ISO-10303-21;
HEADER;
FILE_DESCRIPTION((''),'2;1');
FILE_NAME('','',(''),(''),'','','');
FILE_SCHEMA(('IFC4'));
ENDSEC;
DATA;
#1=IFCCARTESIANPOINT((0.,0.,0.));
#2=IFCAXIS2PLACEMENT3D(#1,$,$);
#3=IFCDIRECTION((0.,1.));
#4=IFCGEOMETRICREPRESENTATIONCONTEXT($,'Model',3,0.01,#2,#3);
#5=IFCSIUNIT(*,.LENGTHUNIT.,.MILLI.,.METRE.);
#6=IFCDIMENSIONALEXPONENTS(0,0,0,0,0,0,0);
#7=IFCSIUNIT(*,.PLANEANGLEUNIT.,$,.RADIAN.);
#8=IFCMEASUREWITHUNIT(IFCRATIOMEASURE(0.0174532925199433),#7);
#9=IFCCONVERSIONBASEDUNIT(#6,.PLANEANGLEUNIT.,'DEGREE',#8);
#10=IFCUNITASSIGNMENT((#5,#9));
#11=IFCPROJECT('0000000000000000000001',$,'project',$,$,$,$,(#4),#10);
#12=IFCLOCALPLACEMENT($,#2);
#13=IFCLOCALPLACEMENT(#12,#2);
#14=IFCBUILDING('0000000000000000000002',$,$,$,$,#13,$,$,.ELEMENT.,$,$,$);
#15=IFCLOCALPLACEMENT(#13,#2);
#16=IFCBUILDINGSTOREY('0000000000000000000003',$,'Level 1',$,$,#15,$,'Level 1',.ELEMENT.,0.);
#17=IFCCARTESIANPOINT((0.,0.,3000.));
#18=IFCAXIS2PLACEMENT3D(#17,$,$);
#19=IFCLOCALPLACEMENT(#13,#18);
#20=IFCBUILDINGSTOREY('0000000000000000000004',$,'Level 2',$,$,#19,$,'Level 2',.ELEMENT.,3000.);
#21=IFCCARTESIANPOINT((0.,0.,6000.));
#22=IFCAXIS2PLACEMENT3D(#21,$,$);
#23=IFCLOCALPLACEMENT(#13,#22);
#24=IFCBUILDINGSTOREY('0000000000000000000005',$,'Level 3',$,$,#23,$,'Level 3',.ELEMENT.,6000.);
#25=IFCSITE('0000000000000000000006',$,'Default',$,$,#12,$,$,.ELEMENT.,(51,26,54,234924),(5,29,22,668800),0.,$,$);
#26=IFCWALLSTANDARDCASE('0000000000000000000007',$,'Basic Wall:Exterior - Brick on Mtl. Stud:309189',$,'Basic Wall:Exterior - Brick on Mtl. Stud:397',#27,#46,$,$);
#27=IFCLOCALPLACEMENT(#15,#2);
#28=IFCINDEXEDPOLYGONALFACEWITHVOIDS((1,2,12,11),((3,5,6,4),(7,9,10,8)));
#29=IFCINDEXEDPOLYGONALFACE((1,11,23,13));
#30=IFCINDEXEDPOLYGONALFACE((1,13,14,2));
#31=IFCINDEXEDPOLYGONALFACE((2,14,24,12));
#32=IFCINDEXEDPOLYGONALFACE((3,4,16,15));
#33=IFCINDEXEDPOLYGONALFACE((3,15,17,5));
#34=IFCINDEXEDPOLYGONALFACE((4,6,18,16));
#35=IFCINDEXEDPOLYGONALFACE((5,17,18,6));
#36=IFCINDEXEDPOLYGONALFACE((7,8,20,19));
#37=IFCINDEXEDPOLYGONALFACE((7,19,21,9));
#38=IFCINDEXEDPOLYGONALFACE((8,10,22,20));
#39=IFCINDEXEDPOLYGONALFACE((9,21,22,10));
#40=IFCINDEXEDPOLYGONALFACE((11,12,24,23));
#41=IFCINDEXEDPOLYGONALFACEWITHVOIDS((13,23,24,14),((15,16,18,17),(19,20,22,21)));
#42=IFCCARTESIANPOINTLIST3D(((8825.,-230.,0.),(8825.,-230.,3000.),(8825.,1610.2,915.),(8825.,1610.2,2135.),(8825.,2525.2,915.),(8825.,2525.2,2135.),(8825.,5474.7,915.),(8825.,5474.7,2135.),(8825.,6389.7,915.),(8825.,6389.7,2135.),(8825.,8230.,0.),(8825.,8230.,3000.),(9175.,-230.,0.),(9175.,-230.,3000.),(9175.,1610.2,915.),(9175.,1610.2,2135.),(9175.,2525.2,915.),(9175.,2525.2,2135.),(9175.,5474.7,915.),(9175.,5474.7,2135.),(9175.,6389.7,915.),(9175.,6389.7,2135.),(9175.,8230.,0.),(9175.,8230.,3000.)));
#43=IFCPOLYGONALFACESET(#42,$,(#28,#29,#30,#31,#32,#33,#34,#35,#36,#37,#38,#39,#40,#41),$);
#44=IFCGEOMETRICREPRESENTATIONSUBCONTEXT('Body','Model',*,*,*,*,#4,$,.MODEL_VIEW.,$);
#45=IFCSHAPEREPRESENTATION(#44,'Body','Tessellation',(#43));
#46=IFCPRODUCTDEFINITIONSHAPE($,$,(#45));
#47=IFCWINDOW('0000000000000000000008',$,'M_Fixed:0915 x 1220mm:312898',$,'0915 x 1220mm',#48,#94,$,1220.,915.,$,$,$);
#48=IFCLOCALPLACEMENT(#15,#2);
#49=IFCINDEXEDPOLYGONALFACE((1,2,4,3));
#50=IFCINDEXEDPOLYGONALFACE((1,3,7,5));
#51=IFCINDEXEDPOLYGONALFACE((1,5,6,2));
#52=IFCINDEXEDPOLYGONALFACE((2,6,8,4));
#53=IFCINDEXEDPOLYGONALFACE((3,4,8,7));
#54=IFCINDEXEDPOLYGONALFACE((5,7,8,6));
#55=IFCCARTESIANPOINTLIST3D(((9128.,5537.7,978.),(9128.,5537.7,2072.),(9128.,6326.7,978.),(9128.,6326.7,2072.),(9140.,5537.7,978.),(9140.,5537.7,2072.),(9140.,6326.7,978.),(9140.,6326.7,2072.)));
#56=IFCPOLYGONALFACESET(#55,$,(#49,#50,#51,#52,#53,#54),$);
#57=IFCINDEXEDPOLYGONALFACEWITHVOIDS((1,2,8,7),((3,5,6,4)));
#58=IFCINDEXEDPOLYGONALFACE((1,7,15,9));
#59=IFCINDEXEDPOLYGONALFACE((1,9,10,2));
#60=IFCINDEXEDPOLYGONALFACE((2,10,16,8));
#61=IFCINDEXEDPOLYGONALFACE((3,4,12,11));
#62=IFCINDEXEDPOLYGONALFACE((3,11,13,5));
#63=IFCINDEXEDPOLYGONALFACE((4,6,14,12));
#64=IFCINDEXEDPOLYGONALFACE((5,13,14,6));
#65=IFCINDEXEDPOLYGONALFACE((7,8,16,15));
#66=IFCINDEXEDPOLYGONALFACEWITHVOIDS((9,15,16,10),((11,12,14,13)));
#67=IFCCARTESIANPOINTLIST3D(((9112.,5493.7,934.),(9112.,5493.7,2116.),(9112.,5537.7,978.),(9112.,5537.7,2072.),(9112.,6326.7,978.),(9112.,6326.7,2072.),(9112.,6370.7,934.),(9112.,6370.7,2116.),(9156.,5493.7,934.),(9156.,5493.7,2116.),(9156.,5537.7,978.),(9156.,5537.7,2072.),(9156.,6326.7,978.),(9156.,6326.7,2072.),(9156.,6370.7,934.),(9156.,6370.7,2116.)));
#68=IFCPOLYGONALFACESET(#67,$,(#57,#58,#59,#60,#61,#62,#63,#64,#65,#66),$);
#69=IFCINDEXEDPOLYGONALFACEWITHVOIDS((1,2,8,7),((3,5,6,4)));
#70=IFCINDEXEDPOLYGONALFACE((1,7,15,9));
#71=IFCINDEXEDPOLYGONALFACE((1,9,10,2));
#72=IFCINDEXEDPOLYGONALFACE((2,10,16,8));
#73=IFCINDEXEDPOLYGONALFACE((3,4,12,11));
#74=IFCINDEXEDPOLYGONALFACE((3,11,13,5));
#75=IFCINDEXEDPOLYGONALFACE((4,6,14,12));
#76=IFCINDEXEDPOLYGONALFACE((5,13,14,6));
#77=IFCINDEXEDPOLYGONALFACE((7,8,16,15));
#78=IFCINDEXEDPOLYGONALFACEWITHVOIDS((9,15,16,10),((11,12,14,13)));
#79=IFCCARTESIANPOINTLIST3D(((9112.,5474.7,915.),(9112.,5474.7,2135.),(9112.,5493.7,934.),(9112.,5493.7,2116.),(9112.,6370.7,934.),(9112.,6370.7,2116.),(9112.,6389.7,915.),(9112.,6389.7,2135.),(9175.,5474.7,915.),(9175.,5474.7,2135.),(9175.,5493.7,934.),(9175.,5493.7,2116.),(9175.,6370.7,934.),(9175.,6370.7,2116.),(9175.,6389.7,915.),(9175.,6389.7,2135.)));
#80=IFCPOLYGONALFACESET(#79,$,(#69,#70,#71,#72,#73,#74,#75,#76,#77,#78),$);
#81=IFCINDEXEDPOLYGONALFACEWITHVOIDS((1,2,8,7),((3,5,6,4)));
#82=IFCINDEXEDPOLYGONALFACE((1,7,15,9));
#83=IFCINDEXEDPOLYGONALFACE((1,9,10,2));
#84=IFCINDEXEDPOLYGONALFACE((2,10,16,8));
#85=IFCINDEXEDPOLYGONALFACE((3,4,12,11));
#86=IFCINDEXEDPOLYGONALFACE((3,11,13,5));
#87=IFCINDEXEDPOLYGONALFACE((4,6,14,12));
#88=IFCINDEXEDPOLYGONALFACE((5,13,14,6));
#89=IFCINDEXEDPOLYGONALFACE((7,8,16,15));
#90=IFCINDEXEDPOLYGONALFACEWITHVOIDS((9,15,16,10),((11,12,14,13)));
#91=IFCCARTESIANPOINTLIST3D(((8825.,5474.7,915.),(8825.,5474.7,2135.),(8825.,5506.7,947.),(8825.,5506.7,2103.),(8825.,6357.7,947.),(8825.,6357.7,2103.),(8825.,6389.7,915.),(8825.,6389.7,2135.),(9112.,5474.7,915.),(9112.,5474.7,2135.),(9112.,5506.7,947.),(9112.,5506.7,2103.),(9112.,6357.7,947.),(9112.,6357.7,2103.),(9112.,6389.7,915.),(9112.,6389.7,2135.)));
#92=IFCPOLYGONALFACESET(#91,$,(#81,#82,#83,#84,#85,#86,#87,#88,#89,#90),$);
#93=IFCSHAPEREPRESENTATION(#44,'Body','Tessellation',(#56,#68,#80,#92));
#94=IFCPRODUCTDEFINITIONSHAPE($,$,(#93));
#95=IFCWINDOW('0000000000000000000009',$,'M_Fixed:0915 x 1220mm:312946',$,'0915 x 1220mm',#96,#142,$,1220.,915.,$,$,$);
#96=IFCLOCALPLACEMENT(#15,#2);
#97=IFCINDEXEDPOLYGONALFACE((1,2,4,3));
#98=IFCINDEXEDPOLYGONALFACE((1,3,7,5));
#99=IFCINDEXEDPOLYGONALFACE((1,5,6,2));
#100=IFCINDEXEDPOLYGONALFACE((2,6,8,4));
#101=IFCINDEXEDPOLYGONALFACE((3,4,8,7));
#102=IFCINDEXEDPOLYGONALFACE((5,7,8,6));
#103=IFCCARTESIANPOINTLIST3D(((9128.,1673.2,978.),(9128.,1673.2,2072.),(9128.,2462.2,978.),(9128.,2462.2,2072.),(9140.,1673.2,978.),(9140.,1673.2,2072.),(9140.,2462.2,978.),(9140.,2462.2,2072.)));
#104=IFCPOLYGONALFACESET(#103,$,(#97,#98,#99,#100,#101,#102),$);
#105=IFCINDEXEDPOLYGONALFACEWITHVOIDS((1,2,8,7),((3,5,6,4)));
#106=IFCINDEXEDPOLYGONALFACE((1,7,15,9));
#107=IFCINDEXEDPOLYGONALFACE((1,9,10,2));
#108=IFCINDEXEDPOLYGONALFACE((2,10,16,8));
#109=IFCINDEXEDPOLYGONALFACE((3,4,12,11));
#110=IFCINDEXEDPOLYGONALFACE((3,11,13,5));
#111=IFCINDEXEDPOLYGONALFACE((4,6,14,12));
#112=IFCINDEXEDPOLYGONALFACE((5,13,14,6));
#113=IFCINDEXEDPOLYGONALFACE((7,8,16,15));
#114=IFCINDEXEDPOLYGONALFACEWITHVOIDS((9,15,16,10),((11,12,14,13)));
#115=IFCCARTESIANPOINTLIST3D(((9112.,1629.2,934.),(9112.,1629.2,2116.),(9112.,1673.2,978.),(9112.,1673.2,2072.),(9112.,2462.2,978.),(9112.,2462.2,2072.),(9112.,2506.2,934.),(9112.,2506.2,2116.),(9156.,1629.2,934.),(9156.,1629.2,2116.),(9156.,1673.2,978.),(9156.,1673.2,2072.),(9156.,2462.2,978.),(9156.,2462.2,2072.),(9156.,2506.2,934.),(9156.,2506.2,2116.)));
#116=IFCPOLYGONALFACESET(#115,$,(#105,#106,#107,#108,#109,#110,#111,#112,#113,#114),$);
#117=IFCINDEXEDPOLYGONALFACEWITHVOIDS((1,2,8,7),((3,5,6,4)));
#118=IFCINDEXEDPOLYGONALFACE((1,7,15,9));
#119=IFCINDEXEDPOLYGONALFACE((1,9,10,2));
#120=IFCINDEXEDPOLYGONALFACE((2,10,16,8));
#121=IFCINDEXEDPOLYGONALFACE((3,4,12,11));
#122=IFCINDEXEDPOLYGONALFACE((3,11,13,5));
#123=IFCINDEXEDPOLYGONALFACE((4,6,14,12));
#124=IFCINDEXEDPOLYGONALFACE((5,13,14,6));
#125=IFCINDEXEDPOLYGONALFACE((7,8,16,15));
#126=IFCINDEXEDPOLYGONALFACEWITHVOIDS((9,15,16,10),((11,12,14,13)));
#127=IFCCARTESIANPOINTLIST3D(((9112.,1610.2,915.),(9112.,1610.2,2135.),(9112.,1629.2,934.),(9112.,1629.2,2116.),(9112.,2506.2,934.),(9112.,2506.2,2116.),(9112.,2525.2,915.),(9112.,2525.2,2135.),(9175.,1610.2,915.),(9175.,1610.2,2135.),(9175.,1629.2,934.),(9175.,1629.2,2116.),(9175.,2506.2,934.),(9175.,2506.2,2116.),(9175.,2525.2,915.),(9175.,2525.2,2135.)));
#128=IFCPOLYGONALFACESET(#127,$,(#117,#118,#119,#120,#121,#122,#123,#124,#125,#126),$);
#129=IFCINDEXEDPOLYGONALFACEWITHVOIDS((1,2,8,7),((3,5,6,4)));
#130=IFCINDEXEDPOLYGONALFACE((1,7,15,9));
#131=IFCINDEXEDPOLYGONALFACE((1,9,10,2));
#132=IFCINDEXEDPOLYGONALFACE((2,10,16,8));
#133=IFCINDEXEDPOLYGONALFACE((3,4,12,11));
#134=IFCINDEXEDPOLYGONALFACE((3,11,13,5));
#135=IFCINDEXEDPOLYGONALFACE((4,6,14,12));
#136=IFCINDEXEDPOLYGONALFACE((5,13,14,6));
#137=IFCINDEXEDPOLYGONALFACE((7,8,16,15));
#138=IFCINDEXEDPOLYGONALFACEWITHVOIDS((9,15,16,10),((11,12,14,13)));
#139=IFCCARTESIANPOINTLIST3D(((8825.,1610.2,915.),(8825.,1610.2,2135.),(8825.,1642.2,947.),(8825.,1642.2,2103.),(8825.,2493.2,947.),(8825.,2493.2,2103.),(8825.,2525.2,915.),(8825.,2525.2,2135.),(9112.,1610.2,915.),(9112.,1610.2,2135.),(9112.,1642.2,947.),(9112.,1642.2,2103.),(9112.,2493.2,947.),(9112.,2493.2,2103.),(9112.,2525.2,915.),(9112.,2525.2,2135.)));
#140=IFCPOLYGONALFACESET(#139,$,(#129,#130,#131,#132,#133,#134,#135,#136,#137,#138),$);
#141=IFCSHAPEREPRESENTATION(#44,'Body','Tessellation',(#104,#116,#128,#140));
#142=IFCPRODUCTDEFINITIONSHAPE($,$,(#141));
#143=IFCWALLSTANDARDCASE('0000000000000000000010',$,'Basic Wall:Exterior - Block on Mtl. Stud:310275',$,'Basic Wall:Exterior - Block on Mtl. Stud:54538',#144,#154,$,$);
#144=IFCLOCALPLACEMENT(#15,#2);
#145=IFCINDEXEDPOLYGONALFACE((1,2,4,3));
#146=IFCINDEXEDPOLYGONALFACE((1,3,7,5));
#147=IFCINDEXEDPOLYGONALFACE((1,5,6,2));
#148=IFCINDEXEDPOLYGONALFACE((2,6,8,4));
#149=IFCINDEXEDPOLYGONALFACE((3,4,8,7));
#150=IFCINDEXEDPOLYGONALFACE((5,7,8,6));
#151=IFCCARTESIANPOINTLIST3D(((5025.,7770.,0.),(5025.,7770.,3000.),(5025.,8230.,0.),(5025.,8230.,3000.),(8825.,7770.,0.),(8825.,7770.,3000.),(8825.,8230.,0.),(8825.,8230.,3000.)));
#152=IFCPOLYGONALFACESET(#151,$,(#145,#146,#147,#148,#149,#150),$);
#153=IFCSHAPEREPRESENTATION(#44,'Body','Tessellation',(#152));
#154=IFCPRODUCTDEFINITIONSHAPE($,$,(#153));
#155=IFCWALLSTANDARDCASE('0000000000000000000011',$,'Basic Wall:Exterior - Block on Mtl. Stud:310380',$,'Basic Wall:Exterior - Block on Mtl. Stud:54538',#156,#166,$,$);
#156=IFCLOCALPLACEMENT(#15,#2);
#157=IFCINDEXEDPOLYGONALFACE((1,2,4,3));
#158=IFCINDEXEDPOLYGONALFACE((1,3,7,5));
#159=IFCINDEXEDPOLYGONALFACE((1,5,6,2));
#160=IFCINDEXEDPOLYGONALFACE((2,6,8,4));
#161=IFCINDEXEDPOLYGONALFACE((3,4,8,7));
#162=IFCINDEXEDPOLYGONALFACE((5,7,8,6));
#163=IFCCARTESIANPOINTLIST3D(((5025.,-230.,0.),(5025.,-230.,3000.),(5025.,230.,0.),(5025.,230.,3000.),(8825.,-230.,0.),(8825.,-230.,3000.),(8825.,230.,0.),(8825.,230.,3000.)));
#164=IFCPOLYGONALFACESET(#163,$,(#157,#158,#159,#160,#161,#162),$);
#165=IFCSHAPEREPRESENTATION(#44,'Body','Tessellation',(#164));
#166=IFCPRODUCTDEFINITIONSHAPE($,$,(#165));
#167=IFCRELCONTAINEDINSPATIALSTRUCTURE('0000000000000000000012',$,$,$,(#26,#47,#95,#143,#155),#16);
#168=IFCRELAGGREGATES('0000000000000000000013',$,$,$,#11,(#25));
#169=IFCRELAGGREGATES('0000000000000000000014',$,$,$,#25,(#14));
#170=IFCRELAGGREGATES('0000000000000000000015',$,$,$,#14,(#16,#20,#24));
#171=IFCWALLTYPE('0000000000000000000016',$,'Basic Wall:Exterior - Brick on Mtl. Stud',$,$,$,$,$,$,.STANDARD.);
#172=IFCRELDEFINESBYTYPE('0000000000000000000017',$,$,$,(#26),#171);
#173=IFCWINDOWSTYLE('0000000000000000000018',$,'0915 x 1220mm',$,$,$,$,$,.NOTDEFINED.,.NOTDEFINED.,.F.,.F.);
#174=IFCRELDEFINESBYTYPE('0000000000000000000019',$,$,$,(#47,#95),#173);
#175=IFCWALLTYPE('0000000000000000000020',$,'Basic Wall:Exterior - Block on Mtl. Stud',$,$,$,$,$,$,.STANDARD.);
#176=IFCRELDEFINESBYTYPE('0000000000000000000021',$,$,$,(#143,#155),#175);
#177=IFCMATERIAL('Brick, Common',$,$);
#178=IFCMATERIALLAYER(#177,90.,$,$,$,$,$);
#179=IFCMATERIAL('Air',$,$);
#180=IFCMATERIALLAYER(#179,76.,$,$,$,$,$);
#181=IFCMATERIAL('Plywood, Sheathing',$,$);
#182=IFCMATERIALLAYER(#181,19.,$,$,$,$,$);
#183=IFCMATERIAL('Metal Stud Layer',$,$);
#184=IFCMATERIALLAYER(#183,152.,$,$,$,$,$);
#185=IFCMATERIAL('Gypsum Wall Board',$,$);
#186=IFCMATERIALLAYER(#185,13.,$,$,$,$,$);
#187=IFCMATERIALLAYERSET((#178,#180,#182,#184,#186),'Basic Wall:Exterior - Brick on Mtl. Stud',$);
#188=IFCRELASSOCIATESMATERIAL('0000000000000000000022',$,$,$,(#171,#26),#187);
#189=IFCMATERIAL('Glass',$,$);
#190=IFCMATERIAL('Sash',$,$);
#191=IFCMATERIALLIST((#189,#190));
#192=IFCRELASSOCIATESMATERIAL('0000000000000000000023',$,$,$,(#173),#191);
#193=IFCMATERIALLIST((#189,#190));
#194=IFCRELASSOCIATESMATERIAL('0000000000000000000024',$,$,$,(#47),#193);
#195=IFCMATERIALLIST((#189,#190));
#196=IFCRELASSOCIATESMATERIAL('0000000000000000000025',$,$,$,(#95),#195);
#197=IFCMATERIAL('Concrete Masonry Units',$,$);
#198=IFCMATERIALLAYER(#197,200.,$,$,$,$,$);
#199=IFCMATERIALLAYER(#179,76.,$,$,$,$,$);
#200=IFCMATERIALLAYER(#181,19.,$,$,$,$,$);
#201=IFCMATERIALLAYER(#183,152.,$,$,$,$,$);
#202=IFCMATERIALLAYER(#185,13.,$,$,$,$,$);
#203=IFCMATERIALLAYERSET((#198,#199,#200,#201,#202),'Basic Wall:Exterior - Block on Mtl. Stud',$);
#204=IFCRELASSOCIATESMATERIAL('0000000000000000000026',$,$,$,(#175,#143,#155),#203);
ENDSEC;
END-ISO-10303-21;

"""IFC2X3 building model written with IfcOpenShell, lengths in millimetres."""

from ifc_helpers import new_model, entity, si_unit, converted_unit, direction, frame, frame_2d, origin, place, context, subcontext, project, spatial, polyline, rectangle, outline, extrude, source, transform, mapped, material, material_list, layer, layer_set, layer_usage, type_object, type_shapes, element, fill, save


model = new_model("IFC2X3")

# Units and contexts
model_context = context("Model", 3, precision=0.01, world=origin(), true_north=direction((0.0, 1.0)))
body_context = subcontext(model_context, "Body", "Model", "MODEL_VIEW")
ifc_project = project(units=[si_unit("LENGTHUNIT", "METRE", prefix="MILLI"), converted_unit("PLANEANGLEUNIT", "DEGREE", entity("IfcRatioMeasure", 0.0174532925199433), si_unit("PLANEANGLEUNIT", "RADIAN"), dimensions=[0, 0, 0, 0, 0, 0, 0])], contexts=[model_context])

# Site, building, storey
site_placement = place(None, origin())
site = spatial("IfcSite", under=ifc_project, at=site_placement, Name="Default", CompositionType="ELEMENT", RefLatitude=(51, 26, 54, 234924), RefLongitude=(5, 29, 22, 668800), RefElevation=0.0)
building_placement = place(site_placement, origin())
building = spatial("IfcBuilding", under=site, at=building_placement, CompositionType="ELEMENT")
storey_1_placement = place(building_placement, origin())
storey_1 = spatial("IfcBuildingStorey", under=building, at=storey_1_placement, Name="Level 1", LongName="Level 1", CompositionType="ELEMENT", Elevation=0.0)

# Wall, openings, windows
ifc_material_1 = material(Name="Brick, Common")
ifc_layer_1 = layer(ifc_material_1, 90.0)
ifc_material_2 = material(Name="Air")
ifc_layer_2 = layer(ifc_material_2, 76.0)
ifc_material_3 = material(Name="Plywood, Sheathing")
ifc_layer_3 = layer(ifc_material_3, 19.0)
ifc_material_4 = material(Name="Metal Stud Layer")
ifc_layer_4 = layer(ifc_material_4, 152.0)
ifc_material_5 = material(Name="Gypsum Wall Board")
ifc_layer_5 = layer(ifc_material_5, 13.0)
ifc_layer_set_1 = layer_set([ifc_layer_1, ifc_layer_2, ifc_layer_3, ifc_layer_4, ifc_layer_5], Name="Basic Wall:Exterior - Brick on Mtl. Stud")
ifc_layer_usage_1 = layer_usage(ifc_layer_set_1, "AXIS2", "NEGATIVE", 175.0)
wall_type_1 = type_object("IfcWallType", Name="Basic Wall:Exterior - Brick on Mtl. Stud", PredefinedType="STANDARD", material=ifc_layer_set_1)
wall_1_placement = place(storey_1_placement, frame((9000.0, 8230.0, 0.0), z_axis=(0.0, 0.0, 1.0), x_axis=(0.0, -1.0, 0.0)))
wall_1 = element("IfcWallStandardCase", 1, at=wall_1_placement, inside=storey_1, type_object=wall_type_1, material=ifc_layer_usage_1, Name="Basic Wall:Exterior - Brick on Mtl. Stud:309189", ObjectType="Basic Wall:Exterior - Brick on Mtl. Stud:397", context=body_context, shape_type="SweptSolid", body=[
    extrude(rectangle(XDim=8460.0, YDim=350.0, at=frame_2d((4230.0, 0.0), x_axis=(-1.0, 0.0))), origin(), (0.0, 0.0, 1.0), 3000.0),
])
opening_1_placement = place(wall_1_placement, frame((1840.3, -175.0, 915.0)))
opening_1 = element("IfcOpeningElement", 2, at=opening_1_placement, cuts=wall_1, ObjectType="Opening", context=body_context, shape_type="SweptSolid", body=[
    extrude(rectangle(XDim=1220.0, YDim=915.0, at=frame_2d((610.0, 457.5), x_axis=(1.0, 0.0))), frame((0.0, 0.0, 0.0), z_axis=(0.0, 1.0, 0.0), x_axis=(0.0, 0.0, 1.0)), (0.0, 0.0, 1.0), 350.0),
])
opening_2_placement = place(wall_1_placement, frame((5704.8, -175.0, 915.0)))
opening_2 = element("IfcOpeningElement", 3, at=opening_2_placement, cuts=wall_1, ObjectType="Opening", context=body_context, shape_type="SweptSolid", body=[
    extrude(rectangle(XDim=1220.0, YDim=915.0, at=frame_2d((610.0, 457.5), x_axis=(1.0, 0.0))), frame((0.0, 0.0, 0.0), z_axis=(0.0, 1.0, 0.0), x_axis=(0.0, 0.0, 1.0)), (0.0, 0.0, 1.0), 350.0),
])
ifc_material_6 = material(Name="Glass")
ifc_material_7 = material(Name="Sash")
ifc_material_list_1 = material_list([ifc_material_6, ifc_material_7])
ifc_material_list_2 = material_list([ifc_material_6, ifc_material_7])
window_style_1 = type_object("IfcWindowStyle", Name="0915 x 1220mm", ConstructionType="NOTDEFINED", OperationType="NOTDEFINED", ParameterTakesPrecedence=False, Sizeable=False, material=ifc_material_list_2)
shared_shape_1 = source(origin(), body_context, "Body", "SweptSolid", [
    extrude(rectangle(XDim=12.0, YDim=789.0, at=frame_2d((0.0, 0.0), x_axis=(1.0, 0.0))), frame((457.5, 309.0, 63.0), z_axis=(0.0, 0.0, 1.0), x_axis=(0.0, -1.0, 0.0)), (0.0, 0.0, 1.0), 1094.0),
    extrude(outline(polyline([(-438.5, -591.0), (438.5, -591.0), (438.5, 591.0), (-438.5, 591.0), (-438.5, -591.0)]), holes=[polyline([(-394.5, -547.0), (-394.5, 547.0), (394.5, 547.0), (394.5, -547.0), (-394.5, -547.0)])]), frame((457.5, 287.0, 610.0), z_axis=(0.0, 1.0, 0.0), x_axis=(1.0, 0.0, 0.0)), (0.0, 0.0, 1.0), 44.0),
    extrude(outline(polyline([(-457.5, -610.0), (457.5, -610.0), (457.5, 610.0), (-457.5, 610.0), (-457.5, -610.0)]), holes=[polyline([(-438.5, -591.0), (-438.5, 591.0), (438.5, 591.0), (438.5, -591.0), (-438.5, -591.0)])]), frame((457.5, 287.0, 610.0), z_axis=(0.0, 1.0, 0.0), x_axis=(1.0, 0.0, 0.0)), (0.0, 0.0, 1.0), 63.0),
    extrude(outline(polyline([(-457.5, -610.0), (457.5, -610.0), (457.5, 610.0), (-457.5, 610.0), (-457.5, -610.0)]), holes=[polyline([(-425.5, -578.0), (-425.5, 578.0), (425.5, 578.0), (425.5, -578.0), (-425.5, -578.0)])]), frame((457.5, 0.0, 610.0), z_axis=(0.0, 1.0, 0.0), x_axis=(1.0, 0.0, 0.0)), (0.0, 0.0, 1.0), 287.0),
])
type_shapes(window_style_1, [shared_shape_1])
window_1_placement = place(opening_1_placement, origin())
window_1 = element("IfcWindow", 4, at=window_1_placement, inside=storey_1, type_object=window_style_1, material=ifc_material_list_1, Name="M_Fixed:0915 x 1220mm:312898", ObjectType="0915 x 1220mm", OverallHeight=1220.0, OverallWidth=915.0, context=body_context, shape_type="MappedRepresentation", body=[
    mapped(shared_shape_1, transform((0.0, 0.0, 0.0), scale=1.0)),
])
fill(opening_1, window_1)
ifc_material_list_3 = material_list([ifc_material_6, ifc_material_7])
window_2_placement = place(opening_2_placement, origin())
window_2 = element("IfcWindow", 5, at=window_2_placement, inside=storey_1, type_object=window_style_1, material=ifc_material_list_3, Name="M_Fixed:0915 x 1220mm:312946", ObjectType="0915 x 1220mm", OverallHeight=1220.0, OverallWidth=915.0, context=body_context, shape_type="MappedRepresentation", body=[
    mapped(shared_shape_1, transform((0.0, 0.0, 0.0), scale=1.0)),
])
fill(opening_2, window_2)

# Shared definitions
ifc_material_8 = material(Name="Concrete Masonry Units")
ifc_layer_6 = layer(ifc_material_8, 200.0)
ifc_layer_7 = layer(ifc_material_2, 76.0)
ifc_layer_8 = layer(ifc_material_3, 19.0)
ifc_layer_9 = layer(ifc_material_4, 152.0)
ifc_layer_10 = layer(ifc_material_5, 13.0)
ifc_layer_set_2 = layer_set([ifc_layer_6, ifc_layer_7, ifc_layer_8, ifc_layer_9, ifc_layer_10], Name="Basic Wall:Exterior - Block on Mtl. Stud")
wall_type_2 = type_object("IfcWallType", Name="Basic Wall:Exterior - Block on Mtl. Stud", PredefinedType="STANDARD", material=ifc_layer_set_2)

# Shared definitions
storey_2_placement = place(building_placement, frame((0.0, 0.0, 3000.0)))
storey_2 = spatial("IfcBuildingStorey", under=building, at=storey_2_placement, Name="Level 2", LongName="Level 2", CompositionType="ELEMENT", Elevation=3000.0)

# Shared definitions
storey_3_placement = place(building_placement, frame((0.0, 0.0, 6000.0)))
storey_3 = spatial("IfcBuildingStorey", under=building, at=storey_3_placement, Name="Level 3", LongName="Level 3", CompositionType="ELEMENT", Elevation=6000.0)

# Walls
ifc_layer_usage_2 = layer_usage(ifc_layer_set_2, "AXIS2", "NEGATIVE", 230.0)
wall_2_placement = place(storey_1_placement, frame((8825.0, 8000.0, 0.0), z_axis=(0.0, 0.0, 1.0), x_axis=(-1.0, 0.0, 0.0)))
element("IfcWallStandardCase", 6, at=wall_2_placement, inside=storey_1, type_object=wall_type_2, material=ifc_layer_usage_2, Name="Basic Wall:Exterior - Block on Mtl. Stud:310275", ObjectType="Basic Wall:Exterior - Block on Mtl. Stud:54538", context=body_context, shape_type="SweptSolid", body=[
    extrude(rectangle(XDim=3800.0, YDim=460.0, at=frame_2d((1900.0, 0.0), x_axis=(-1.0, 0.0))), origin(), (0.0, 0.0, 1.0), 3000.0),
])
ifc_layer_usage_3 = layer_usage(ifc_layer_set_2, "AXIS2", "NEGATIVE", 230.0)
wall_3_placement = place(storey_1_placement, frame((8825.0, 0.0, 0.0), z_axis=(0.0, 0.0, 1.0), x_axis=(-1.0, 0.0, 0.0)))
element("IfcWallStandardCase", 7, at=wall_3_placement, inside=storey_1, type_object=wall_type_2, material=ifc_layer_usage_3, Name="Basic Wall:Exterior - Block on Mtl. Stud:310380", ObjectType="Basic Wall:Exterior - Block on Mtl. Stud:54538", context=body_context, shape_type="SweptSolid", body=[
    extrude(rectangle(XDim=3800.0, YDim=460.0, at=frame_2d((1900.0, 0.0), x_axis=(-1.0, 0.0))), origin(), (0.0, 0.0, 1.0), 3000.0),
])

save(model, "model.ifc")
